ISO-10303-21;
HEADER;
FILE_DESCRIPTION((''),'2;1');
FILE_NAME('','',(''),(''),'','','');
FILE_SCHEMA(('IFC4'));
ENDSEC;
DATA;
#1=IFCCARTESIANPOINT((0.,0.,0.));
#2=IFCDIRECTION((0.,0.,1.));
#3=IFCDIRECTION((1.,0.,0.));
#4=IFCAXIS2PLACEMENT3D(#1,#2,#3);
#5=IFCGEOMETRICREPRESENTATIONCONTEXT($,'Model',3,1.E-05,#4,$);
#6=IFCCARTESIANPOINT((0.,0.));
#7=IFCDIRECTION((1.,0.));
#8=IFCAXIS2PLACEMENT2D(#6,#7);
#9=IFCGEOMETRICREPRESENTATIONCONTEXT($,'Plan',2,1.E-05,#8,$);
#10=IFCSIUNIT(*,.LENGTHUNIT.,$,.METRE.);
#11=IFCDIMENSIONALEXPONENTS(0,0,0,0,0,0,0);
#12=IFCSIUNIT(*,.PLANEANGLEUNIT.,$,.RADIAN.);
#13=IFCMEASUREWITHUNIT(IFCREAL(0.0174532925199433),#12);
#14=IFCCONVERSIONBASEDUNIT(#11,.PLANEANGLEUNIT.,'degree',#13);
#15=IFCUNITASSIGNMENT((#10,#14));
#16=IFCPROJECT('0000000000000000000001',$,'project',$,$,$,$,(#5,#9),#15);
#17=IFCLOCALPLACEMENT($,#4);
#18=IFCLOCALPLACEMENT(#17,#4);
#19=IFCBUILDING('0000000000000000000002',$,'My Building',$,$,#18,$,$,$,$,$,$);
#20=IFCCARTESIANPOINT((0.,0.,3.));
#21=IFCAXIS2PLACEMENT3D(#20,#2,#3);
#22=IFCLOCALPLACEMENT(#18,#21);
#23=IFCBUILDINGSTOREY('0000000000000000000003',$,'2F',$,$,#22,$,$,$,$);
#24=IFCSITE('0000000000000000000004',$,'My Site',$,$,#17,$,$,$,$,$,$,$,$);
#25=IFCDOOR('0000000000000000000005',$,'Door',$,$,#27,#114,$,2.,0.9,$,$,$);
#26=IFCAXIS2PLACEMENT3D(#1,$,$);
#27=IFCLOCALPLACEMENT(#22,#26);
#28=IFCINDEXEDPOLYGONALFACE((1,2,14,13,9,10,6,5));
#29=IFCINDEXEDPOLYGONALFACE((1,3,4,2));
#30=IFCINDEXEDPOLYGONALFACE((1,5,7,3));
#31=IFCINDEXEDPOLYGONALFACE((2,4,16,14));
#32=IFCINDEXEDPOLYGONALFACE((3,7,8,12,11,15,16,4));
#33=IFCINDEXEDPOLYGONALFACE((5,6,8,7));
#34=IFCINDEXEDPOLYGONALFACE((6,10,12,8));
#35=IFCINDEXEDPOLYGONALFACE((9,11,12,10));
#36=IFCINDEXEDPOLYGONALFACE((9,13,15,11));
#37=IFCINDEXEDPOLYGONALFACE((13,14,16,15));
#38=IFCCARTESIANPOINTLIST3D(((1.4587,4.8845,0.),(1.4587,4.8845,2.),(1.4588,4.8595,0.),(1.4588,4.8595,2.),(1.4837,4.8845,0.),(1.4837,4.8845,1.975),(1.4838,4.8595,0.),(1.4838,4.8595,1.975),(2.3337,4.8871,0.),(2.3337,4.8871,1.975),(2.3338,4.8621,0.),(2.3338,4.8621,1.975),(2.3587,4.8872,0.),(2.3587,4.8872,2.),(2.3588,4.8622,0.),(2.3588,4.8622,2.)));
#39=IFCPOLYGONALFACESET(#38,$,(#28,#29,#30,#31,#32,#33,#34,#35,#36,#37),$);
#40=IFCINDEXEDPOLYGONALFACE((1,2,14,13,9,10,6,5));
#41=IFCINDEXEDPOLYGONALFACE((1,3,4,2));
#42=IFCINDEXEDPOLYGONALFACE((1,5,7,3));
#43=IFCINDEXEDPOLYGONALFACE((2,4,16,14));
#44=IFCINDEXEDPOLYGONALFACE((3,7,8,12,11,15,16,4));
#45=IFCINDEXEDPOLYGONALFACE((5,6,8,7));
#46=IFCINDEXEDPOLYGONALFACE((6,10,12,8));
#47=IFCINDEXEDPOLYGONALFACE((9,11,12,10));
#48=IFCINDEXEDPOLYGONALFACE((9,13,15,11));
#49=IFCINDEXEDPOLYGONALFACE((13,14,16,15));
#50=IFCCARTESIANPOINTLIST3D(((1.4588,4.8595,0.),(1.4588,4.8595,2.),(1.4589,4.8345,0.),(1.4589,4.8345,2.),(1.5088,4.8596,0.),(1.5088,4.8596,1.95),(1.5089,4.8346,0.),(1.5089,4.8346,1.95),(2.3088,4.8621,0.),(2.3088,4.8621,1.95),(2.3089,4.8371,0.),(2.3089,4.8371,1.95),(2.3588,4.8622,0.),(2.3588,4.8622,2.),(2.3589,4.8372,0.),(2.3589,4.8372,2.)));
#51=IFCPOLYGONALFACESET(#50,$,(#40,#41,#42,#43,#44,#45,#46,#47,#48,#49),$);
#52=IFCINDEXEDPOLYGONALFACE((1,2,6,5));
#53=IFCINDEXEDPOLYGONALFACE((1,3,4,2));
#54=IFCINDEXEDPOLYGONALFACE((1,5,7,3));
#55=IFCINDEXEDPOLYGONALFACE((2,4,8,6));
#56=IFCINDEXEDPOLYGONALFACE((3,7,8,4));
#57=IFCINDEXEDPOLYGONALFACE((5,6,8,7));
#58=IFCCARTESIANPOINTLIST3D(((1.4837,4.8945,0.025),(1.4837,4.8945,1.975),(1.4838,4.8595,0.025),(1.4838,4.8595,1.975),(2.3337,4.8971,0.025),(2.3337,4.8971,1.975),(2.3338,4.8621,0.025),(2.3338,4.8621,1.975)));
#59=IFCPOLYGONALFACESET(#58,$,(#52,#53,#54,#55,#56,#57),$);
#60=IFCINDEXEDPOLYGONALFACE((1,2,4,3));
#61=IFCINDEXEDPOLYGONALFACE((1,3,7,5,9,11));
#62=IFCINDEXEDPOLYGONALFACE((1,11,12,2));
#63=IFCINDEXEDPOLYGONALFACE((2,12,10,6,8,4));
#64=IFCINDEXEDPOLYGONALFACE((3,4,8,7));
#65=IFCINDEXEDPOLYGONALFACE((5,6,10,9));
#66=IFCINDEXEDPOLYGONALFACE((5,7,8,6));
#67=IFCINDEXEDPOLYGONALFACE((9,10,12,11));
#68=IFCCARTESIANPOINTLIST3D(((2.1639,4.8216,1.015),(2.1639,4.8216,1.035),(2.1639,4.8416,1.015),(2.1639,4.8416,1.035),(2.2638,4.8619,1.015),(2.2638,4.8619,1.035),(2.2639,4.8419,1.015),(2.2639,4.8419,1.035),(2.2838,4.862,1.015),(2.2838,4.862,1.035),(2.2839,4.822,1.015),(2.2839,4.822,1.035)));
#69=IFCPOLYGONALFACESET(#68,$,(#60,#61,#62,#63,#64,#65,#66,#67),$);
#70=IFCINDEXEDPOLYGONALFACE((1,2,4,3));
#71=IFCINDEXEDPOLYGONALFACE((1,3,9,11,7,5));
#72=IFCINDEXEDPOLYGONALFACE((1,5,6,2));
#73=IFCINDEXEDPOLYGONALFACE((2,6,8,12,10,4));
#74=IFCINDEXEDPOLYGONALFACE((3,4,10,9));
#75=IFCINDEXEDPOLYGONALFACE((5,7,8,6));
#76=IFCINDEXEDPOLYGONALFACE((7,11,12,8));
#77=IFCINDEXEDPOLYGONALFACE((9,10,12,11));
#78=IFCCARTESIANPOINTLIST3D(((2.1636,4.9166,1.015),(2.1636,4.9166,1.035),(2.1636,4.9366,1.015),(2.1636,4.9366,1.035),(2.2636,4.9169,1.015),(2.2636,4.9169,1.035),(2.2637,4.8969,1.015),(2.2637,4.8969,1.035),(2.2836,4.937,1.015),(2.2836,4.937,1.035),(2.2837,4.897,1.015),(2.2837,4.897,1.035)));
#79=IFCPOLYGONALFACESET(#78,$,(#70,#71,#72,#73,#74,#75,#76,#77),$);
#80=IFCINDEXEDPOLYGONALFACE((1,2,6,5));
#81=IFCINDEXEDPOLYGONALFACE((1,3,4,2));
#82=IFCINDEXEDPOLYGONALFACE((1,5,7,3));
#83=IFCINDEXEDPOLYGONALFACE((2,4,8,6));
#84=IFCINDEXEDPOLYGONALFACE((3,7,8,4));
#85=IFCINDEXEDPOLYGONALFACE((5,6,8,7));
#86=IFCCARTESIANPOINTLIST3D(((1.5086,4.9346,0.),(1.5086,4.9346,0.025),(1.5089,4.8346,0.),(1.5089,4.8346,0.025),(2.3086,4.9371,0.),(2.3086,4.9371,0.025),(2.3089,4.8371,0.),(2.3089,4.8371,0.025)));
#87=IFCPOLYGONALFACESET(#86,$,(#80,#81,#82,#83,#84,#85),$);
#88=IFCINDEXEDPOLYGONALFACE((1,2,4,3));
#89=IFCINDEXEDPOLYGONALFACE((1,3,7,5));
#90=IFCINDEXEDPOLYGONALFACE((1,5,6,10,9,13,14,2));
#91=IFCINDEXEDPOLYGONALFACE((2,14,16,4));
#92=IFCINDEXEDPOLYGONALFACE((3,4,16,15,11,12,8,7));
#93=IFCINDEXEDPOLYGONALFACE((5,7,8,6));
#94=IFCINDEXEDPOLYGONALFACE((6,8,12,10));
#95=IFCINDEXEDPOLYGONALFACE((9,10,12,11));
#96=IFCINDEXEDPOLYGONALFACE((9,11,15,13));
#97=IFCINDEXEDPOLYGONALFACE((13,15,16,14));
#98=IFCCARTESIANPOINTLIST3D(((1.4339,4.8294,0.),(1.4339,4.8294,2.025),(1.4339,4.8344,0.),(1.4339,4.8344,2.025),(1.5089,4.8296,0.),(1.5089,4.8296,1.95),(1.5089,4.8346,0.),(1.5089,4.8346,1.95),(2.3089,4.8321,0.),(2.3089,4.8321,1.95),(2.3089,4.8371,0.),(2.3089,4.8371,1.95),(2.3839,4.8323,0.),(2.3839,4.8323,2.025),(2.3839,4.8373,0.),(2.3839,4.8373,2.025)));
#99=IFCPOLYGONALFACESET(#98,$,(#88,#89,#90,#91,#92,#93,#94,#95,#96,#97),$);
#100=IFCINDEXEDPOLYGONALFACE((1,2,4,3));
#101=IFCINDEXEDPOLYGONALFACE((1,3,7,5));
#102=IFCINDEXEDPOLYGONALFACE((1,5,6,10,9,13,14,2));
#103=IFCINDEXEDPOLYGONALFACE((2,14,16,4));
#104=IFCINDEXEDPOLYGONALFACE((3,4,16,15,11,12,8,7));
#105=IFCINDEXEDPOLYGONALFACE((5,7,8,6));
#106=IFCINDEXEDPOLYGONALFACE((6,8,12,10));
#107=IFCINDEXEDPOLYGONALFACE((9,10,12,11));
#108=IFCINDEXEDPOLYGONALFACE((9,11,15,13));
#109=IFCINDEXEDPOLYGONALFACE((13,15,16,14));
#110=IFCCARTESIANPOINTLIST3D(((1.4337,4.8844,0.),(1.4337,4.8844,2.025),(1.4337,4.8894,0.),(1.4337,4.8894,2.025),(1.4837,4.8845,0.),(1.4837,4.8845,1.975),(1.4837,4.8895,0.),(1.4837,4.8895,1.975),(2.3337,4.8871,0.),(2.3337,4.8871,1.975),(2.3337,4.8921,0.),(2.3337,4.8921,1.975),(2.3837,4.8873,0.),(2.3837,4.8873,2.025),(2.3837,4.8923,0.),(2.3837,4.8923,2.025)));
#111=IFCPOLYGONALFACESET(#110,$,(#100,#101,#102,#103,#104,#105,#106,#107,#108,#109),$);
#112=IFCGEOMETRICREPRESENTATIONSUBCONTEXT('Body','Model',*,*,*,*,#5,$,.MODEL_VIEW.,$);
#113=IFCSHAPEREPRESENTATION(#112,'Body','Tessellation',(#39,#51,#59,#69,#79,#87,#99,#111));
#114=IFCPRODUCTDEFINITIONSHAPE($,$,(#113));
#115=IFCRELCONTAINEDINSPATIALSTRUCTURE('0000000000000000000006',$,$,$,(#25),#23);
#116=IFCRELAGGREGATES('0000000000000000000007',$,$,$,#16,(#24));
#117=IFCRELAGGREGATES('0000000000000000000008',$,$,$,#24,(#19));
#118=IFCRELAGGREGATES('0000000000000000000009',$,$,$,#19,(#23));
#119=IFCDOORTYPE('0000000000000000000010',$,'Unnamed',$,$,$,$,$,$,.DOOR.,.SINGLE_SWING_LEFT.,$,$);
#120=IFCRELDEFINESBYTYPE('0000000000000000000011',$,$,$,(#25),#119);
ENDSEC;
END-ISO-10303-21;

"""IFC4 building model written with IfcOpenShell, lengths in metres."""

from ifc_helpers import new_model, entity, si_unit, converted_unit, frame, origin_with_axes, origin_2d_with_axis, place, context, subcontext, project, spatial, line, indexed_curve, outline, extrude, shape, source, transform, mapped, type_object, type_shapes, element, save


model = new_model("IFC4")

# Units and contexts
model_context = context("Model", 3, precision=1e-05, world=origin_with_axes())
plan_context = context("Plan", 2, precision=1e-05, world=origin_2d_with_axis())
body_context_1 = subcontext(model_context, "Body", "Model", "MODEL_VIEW")
body_context_2 = subcontext(plan_context, "Body", "Plan", "PLAN_VIEW")
ifc_project = project(units=[si_unit("LENGTHUNIT", "METRE"), converted_unit("PLANEANGLEUNIT", "degree", entity("IfcReal", 0.0174532925199433), si_unit("PLANEANGLEUNIT", "RADIAN"), dimensions=[0, 0, 0, 0, 0, 0, 0])], contexts=[model_context, plan_context])

# Site, building, storey
site_placement = place(None, origin_with_axes())
site = spatial("IfcSite", under=ifc_project, at=site_placement, Name="My Site")
building_placement = place(site_placement, origin_with_axes())
building = spatial("IfcBuilding", under=site, at=building_placement, Name="My Building")
storey_placement = place(building_placement, frame((0.0, 0.0, 3.0), z_axis=(0.0, 0.0, 1.0), x_axis=(1.0, 0.0, 0.0)))
storey = spatial("IfcBuildingStorey", under=building, at=storey_placement, Name="2F")

# Shared definitions
door_type = type_object("IfcDoorType", Name="Unnamed", OperationType="SINGLE_SWING_LEFT", PredefinedType="DOOR")
shared_shape_1 = source(origin_with_axes(), body_context_1, "Body", "SweptSolid", [
    extrude(outline(indexed_curve([(0.0, 0.0), (0.0, 2.0), (0.9, 2.0), (0.9, 0.0), (0.875, 0.0), (0.875, 1.975), (0.025, 1.975), (0.025, 0.0)], segments=[line(1, 2, 3, 4, 5, 6, 7, 8, 1)])), frame((0.0, 0.025, 0.0), z_axis=(0.0, -1.0, 0.0), x_axis=(1.0, 0.0, 0.0)), (0.0, 0.0, -1.0), 0.025),
    extrude(outline(indexed_curve([(0.0, 0.0), (0.0, 2.0), (0.9, 2.0), (0.9, 0.0), (0.85, 0.0), (0.85, 1.95), (0.05, 1.95), (0.05, 0.0)], segments=[line(1, 2, 3, 4, 5, 6, 7, 8, 1)])), frame((0.0, 0.0, 0.0), z_axis=(0.0, -1.0, 0.0), x_axis=(1.0, 0.0, 0.0)), (0.0, 0.0, -1.0), 0.025),
    extrude(outline(indexed_curve([(0.0, 0.0), (0.85, 0.0), (0.85, 0.035), (0.0, 0.035)], segments=[line(1, 2, 3, 4, 1)])), frame((0.025, 0.025, 0.025), z_axis=(0.0, 0.0, 1.0), x_axis=(1.0, 0.0, 0.0)), (0.0, 0.0, 1.0), 1.95),
    extrude(outline(indexed_curve([(0.0, 0.0), (0.0, -0.04), (-0.12, -0.04), (-0.12, -0.02), (-0.02, -0.02), (-0.02, 0.0)], segments=[line(1, 2, 3, 4, 5, 6, 1)])), frame((0.825, 0.025, 1.015), z_axis=(0.0, 0.0, 1.0), x_axis=(1.0, 0.0, 0.0)), (0.0, 0.0, 1.0), 0.02),
    extrude(outline(indexed_curve([(0.0, 0.0), (0.0, 0.04), (-0.12, 0.04), (-0.12, 0.02), (-0.02, 0.02), (-0.02, 0.0)], segments=[line(1, 2, 3, 4, 5, 6, 1)])), frame((0.825, 0.06, 1.015), z_axis=(0.0, 0.0, 1.0), x_axis=(1.0, 0.0, 0.0)), (0.0, 0.0, 1.0), 0.02),
    extrude(outline(indexed_curve([(0.0, 0.0), (0.8, 0.0), (0.8, 0.1), (0.0, 0.1)], segments=[line(1, 2, 3, 4, 1)])), frame((0.05, 0.0, 0.0), z_axis=(0.0, 0.0, 1.0), x_axis=(1.0, 0.0, 0.0)), (0.0, 0.0, 1.0), 0.025),
    extrude(outline(indexed_curve([(0.0, 0.0), (0.0, 2.025), (0.95, 2.025), (0.95, 0.0), (0.875, 0.0), (0.875, 1.95), (0.075, 1.95), (0.075, 0.0)], segments=[line(1, 2, 3, 4, 5, 6, 7, 8, 1)])), frame((-0.025, -0.005, 0.0), z_axis=(0.0, -1.0, 0.0), x_axis=(1.0, 0.0, 0.0)), (0.0, 0.0, -1.0), 0.005),
    extrude(outline(indexed_curve([(0.0, 0.0), (0.0, 2.025), (0.95, 2.025), (0.95, 0.0), (0.9, 0.0), (0.9, 1.975), (0.05, 1.975), (0.05, 0.0)], segments=[line(1, 2, 3, 4, 5, 6, 7, 8, 1)])), frame((-0.025, 0.05, 0.0), z_axis=(0.0, -1.0, 0.0), x_axis=(1.0, 0.0, 0.0)), (0.0, 0.0, -1.0), 0.005),
])
shared_shape_2 = source(origin_with_axes(), body_context_2, "Body", "Curve2D", [
    entity("IfcIndexedPolyCurve", entity("IfcCartesianPointList2D", [[0.0, 0.0], [0.0, 0.05], [0.025, 0.05], [0.025, 0.025], [0.05, 0.025], [0.05, 0.0]]), [entity("IfcLineIndex", [1, 2, 3, 4, 5, 6, 1])]),
    entity("IfcIndexedPolyCurve", entity("IfcCartesianPointList2D", [[0.9, 0.0], [0.9, 0.05], [0.875, 0.05], [0.875, 0.025], [0.85, 0.025], [0.85, 0.0]]), [entity("IfcLineIndex", [1, 2, 3, 4, 5, 6, 1])]),
    entity("IfcTrimmedCurve", entity("IfcEllipse", entity("IfcAxis2Placement2D", entity("IfcCartesianPoint", [0.06, 0.05]), entity("IfcDirection", [1.0, 0.0])), 0.815, 0.85), [entity("IfcCartesianPoint", [0.875, 0.05])], [entity("IfcCartesianPoint", [0.06, 0.9])], True, "CARTESIAN"),
    entity("IfcIndexedPolyCurve", entity("IfcCartesianPointList2D", [[0.025, 0.05], [0.06, 0.05], [0.06, 0.9], [0.025, 0.9]]), [entity("IfcLineIndex", [1, 2, 3, 4, 1])]),
])
type_shapes(door_type, [shared_shape_1, shared_shape_2])

# Door
door_1_placement = place(storey_placement, frame((1.4589, 4.8345, 0.0), z_axis=(0.0, 0.0, 1.0), x_axis=(0.999995, 0.003068, 0.0)))
element("IfcDoor", 1, at=door_1_placement, inside=storey, type_object=door_type, Name="Door", OverallHeight=2.0, OverallWidth=0.9, shapes=[
    shape(body_context_1, "Body", "MappedRepresentation", [mapped(shared_shape_1, transform((0.0, 0.0, 0.0), x_axis=(1.0, 0.0, 0.0), y_axis=(0.0, 1.0, 0.0), z_axis=(0.0, 0.0, 1.0), scale=1.0))]),
    shape(body_context_2, "Body", "MappedRepresentation", [mapped(shared_shape_2, transform((0.0, 0.0, 0.0), x_axis=(1.0, 0.0, 0.0), y_axis=(0.0, 1.0, 0.0), z_axis=(0.0, 0.0, 1.0), scale=1.0))]),
])

save(model, "model.ifc")
